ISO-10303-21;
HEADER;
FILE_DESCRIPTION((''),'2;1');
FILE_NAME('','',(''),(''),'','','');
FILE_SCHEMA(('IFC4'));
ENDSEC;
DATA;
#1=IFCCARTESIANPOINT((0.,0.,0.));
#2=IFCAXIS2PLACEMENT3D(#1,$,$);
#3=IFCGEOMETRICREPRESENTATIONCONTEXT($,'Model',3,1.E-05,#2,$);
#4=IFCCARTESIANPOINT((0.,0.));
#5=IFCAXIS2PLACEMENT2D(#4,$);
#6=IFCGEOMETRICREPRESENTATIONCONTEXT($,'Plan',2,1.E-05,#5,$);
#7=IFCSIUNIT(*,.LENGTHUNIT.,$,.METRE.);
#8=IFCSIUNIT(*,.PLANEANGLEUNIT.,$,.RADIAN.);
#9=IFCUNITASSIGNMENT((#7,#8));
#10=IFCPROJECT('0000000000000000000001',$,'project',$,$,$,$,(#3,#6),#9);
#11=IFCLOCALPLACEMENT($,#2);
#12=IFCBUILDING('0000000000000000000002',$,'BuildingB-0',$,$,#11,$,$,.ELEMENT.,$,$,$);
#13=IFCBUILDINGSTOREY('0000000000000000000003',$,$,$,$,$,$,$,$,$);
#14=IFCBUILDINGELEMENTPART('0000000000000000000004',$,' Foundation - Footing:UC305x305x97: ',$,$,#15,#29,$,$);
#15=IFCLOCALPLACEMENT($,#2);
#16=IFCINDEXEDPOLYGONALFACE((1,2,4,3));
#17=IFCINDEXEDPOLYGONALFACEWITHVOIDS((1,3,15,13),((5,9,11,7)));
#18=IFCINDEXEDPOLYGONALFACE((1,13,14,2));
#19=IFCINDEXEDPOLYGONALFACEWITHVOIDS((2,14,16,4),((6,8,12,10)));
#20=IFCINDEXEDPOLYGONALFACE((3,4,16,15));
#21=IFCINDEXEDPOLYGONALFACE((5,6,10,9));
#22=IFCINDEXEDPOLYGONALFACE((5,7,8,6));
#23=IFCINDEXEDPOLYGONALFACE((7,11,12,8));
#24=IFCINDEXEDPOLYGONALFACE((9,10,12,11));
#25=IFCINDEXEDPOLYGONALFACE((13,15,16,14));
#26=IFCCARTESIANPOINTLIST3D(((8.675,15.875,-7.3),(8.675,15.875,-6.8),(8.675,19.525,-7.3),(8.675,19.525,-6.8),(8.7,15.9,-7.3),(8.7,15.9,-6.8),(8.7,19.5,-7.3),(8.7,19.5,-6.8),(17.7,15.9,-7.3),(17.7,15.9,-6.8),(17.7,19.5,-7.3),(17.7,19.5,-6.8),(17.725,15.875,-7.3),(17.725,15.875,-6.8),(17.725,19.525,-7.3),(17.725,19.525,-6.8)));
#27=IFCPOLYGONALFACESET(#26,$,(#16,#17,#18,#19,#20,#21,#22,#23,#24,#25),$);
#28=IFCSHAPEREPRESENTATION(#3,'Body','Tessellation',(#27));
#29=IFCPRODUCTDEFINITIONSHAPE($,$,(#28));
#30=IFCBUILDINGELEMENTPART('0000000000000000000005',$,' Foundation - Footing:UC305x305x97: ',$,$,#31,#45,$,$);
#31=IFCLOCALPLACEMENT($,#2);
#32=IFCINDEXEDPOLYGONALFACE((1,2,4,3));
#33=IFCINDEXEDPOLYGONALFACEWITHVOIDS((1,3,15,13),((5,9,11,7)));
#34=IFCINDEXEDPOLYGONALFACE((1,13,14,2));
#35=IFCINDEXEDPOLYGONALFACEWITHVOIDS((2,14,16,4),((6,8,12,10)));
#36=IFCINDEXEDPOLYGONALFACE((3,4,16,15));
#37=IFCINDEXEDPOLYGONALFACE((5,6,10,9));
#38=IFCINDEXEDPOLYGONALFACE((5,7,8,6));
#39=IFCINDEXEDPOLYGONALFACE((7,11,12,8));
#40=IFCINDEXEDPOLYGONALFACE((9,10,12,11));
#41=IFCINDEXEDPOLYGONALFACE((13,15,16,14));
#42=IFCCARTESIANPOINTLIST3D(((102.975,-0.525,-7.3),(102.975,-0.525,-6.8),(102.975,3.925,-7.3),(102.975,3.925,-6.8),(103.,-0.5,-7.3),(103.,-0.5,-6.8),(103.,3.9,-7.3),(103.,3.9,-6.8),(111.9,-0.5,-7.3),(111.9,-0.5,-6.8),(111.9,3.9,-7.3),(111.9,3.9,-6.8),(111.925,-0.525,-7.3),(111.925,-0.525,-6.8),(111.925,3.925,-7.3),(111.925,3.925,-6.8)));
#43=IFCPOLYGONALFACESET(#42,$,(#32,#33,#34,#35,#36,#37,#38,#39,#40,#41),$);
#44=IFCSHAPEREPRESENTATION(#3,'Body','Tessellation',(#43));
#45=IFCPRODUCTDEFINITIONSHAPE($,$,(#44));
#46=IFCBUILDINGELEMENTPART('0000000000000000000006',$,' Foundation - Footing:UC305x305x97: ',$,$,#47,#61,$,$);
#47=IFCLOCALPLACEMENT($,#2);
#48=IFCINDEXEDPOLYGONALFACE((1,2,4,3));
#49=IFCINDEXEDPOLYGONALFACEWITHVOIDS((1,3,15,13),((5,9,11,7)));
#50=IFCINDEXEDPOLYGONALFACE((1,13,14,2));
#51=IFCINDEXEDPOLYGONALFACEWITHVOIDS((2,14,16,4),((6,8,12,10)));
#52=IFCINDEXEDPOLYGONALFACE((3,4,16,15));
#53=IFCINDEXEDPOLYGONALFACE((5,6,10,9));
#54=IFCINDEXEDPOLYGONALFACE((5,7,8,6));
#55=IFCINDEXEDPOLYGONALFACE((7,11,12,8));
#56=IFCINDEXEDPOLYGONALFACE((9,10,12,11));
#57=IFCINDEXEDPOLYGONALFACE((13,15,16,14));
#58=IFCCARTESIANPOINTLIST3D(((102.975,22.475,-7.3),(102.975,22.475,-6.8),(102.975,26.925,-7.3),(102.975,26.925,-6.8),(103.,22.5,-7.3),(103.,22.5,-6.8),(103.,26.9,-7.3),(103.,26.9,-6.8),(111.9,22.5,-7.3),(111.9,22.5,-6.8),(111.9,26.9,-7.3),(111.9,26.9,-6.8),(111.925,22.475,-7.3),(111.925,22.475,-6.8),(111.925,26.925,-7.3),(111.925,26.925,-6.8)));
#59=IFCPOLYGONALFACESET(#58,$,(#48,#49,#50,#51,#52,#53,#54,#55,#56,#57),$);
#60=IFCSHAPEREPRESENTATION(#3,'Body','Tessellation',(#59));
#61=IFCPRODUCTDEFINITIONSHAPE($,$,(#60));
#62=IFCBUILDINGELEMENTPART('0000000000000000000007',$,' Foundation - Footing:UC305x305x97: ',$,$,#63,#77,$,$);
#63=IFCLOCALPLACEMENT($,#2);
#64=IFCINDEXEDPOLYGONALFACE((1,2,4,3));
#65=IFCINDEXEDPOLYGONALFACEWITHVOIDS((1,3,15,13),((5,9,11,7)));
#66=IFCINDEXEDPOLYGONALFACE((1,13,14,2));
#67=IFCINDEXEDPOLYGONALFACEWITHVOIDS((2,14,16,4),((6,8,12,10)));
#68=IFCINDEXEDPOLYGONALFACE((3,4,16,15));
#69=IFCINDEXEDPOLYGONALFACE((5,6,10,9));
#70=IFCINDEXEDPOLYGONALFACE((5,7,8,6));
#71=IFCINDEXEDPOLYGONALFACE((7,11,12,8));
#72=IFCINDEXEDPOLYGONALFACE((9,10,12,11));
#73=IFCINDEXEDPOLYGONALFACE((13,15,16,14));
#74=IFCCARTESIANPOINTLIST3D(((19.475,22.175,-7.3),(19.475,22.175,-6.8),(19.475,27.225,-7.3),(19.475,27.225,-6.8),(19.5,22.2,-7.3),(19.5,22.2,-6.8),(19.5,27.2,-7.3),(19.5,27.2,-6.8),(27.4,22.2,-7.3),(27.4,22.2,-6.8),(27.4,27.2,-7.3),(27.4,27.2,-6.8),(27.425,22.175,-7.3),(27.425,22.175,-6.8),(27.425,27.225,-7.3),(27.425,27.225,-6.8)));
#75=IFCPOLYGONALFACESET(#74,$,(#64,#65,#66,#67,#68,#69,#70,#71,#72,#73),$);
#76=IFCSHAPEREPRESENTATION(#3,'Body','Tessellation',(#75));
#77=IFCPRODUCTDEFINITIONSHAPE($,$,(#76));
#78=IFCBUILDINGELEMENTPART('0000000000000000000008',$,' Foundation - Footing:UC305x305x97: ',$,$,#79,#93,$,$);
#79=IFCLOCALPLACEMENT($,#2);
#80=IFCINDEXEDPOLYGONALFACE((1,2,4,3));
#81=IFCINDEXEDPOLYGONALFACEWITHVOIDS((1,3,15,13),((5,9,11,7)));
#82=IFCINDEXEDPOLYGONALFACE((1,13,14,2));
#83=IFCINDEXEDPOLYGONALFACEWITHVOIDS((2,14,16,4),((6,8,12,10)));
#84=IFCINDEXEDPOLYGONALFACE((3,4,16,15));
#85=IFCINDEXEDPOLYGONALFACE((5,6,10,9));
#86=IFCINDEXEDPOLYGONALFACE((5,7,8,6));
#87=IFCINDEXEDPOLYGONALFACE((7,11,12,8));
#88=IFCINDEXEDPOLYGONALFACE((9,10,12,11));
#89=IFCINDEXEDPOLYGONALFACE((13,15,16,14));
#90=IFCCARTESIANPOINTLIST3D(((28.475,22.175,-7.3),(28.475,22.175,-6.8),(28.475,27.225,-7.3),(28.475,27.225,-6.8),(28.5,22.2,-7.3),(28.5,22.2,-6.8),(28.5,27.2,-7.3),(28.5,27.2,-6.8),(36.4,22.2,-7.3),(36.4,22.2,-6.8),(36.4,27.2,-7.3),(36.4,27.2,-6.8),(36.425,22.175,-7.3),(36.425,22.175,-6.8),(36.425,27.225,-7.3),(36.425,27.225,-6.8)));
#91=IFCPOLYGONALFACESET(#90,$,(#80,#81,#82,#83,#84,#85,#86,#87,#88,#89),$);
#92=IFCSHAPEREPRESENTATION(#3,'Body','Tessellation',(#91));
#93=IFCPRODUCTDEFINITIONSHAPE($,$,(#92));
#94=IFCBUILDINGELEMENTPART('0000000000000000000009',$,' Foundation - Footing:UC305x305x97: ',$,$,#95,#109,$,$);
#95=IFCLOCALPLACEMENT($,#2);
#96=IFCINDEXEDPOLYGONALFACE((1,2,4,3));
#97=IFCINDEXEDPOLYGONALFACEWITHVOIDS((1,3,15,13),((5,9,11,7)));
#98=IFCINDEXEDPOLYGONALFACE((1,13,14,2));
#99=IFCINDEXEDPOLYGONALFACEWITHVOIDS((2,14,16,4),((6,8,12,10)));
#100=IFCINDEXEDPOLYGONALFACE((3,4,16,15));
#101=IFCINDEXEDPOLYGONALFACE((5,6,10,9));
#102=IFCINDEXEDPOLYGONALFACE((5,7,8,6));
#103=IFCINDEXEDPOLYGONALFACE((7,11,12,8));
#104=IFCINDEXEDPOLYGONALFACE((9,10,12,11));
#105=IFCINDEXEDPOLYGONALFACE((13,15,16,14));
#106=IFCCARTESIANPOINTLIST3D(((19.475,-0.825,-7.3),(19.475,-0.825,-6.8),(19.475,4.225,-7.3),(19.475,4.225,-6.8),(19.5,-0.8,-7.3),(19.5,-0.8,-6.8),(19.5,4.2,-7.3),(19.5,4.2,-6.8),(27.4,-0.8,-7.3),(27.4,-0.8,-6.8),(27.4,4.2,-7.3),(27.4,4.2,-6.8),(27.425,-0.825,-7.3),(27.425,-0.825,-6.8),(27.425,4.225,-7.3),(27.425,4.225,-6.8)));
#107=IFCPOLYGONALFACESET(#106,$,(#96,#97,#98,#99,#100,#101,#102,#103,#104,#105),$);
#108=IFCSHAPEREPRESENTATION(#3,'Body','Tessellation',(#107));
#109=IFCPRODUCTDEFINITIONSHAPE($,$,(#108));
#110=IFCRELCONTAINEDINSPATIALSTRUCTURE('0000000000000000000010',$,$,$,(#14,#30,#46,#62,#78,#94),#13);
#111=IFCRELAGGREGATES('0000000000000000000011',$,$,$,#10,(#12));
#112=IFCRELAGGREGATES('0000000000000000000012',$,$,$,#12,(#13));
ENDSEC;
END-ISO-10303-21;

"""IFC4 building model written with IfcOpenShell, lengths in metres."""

from ifc_helpers import new_model, si_unit, origin, origin_2d, place, context, project, spatial, polyline, outline, extrude, element, save


model = new_model("IFC4")

# Units and contexts
model_context = context("Model", 3, precision=1e-05, world=origin())
plan_context = context("Plan", 2, precision=1e-05, world=origin_2d())
ifc_project = project(units=[si_unit("LENGTHUNIT", "METRE"), si_unit("PLANEANGLEUNIT", "RADIAN")], contexts=[model_context, plan_context])

# Building, storey
building_placement = place(None, origin())
building = spatial("IfcBuilding", under=ifc_project, at=building_placement, Name="BuildingB-0", CompositionType="ELEMENT")
storey = spatial("IfcBuildingStorey", under=building)

# Building element parts, openings
building_element_part_1 = element("IfcBuildingElementPart", 1, inside=storey, Name=" Foundation - Footing:UC305x305x97: ", context=model_context, shape_type="SweptSolid", body=[
    extrude(outline(polyline([(17.725, 19.525, -7.3), (8.675, 19.525, -7.3), (8.675, 15.875, -7.3), (17.725, 15.875, -7.3), (17.725, 19.525, -7.3)])), None, (0.0, 0.0, 1.0), 0.5),
])
element("IfcOpeningElement", 2, inside=storey, cuts=building_element_part_1, context=model_context, shape_type="SweptSolid", body=[
    extrude(outline(polyline([(17.7, 19.5, -7.3), (8.7, 19.5, -7.3), (8.7, 15.9, -7.3), (17.7, 15.9, -7.3), (17.7, 19.5, -7.3)])), None, (0.0, 0.0, 1.0), 0.5),
])
building_element_part_2 = element("IfcBuildingElementPart", 3, inside=storey, Name=" Foundation - Footing:UC305x305x97: ", context=model_context, shape_type="SweptSolid", body=[
    extrude(outline(polyline([(111.925, 3.925, -7.3), (102.975, 3.925, -7.3), (102.975, -0.525, -7.3), (111.925, -0.525, -7.3), (111.925, 3.925, -7.3)])), None, (0.0, 0.0, 1.0), 0.5),
])
element("IfcOpeningElement", 4, inside=storey, cuts=building_element_part_2, context=model_context, shape_type="SweptSolid", body=[
    extrude(outline(polyline([(111.9, 3.9, -7.3), (103.0, 3.9, -7.3), (103.0, -0.5, -7.3), (111.9, -0.5, -7.3), (111.9, 3.9, -7.3)])), None, (0.0, 0.0, 1.0), 0.5),
])
building_element_part_3 = element("IfcBuildingElementPart", 5, inside=storey, Name=" Foundation - Footing:UC305x305x97: ", context=model_context, shape_type="SweptSolid", body=[
    extrude(outline(polyline([(111.925, 26.925, -7.3), (102.975, 26.925, -7.3), (102.975, 22.475, -7.3), (111.925, 22.475, -7.3), (111.925, 26.925, -7.3)])), None, (0.0, 0.0, 1.0), 0.5),
])
element("IfcOpeningElement", 6, inside=storey, cuts=building_element_part_3, context=model_context, shape_type="SweptSolid", body=[
    extrude(outline(polyline([(111.9, 26.9, -7.3), (103.0, 26.9, -7.3), (103.0, 22.5, -7.3), (111.9, 22.5, -7.3), (111.9, 26.9, -7.3)])), None, (0.0, 0.0, 1.0), 0.5),
])
building_element_part_4 = element("IfcBuildingElementPart", 7, inside=storey, Name=" Foundation - Footing:UC305x305x97: ", context=model_context, shape_type="SweptSolid", body=[
    extrude(outline(polyline([(27.425, 27.225, -7.3), (19.475, 27.225, -7.3), (19.475, 22.175, -7.3), (27.425, 22.175, -7.3), (27.425, 27.225, -7.3)])), None, (0.0, 0.0, 1.0), 0.5),
])
element("IfcOpeningElement", 8, inside=storey, cuts=building_element_part_4, context=model_context, shape_type="SweptSolid", body=[
    extrude(outline(polyline([(27.4, 27.2, -7.3), (19.5, 27.2, -7.3), (19.5, 22.2, -7.3), (27.4, 22.2, -7.3), (27.4, 27.2, -7.3)])), None, (0.0, 0.0, 1.0), 0.5),
])
building_element_part_5 = element("IfcBuildingElementPart", 9, inside=storey, Name=" Foundation - Footing:UC305x305x97: ", context=model_context, shape_type="SweptSolid", body=[
    extrude(outline(polyline([(36.425, 27.225, -7.3), (28.475, 27.225, -7.3), (28.475, 22.175, -7.3), (36.425, 22.175, -7.3), (36.425, 27.225, -7.3)])), None, (0.0, 0.0, 1.0), 0.5),
])
element("IfcOpeningElement", 10, inside=storey, cuts=building_element_part_5, context=model_context, shape_type="SweptSolid", body=[
    extrude(outline(polyline([(36.4, 27.2, -7.3), (28.5, 27.2, -7.3), (28.5, 22.2, -7.3), (36.4, 22.2, -7.3), (36.4, 27.2, -7.3)])), None, (0.0, 0.0, 1.0), 0.5),
])
building_element_part_6 = element("IfcBuildingElementPart", 11, inside=storey, Name=" Foundation - Footing:UC305x305x97: ", context=model_context, shape_type="SweptSolid", body=[
    extrude(outline(polyline([(27.425, 4.225, -7.3), (19.475, 4.225, -7.3), (19.475, -0.825, -7.3), (27.425, -0.825, -7.3), (27.425, 4.225, -7.3)])), None, (0.0, 0.0, 1.0), 0.5),
])
element("IfcOpeningElement", 12, inside=storey, cuts=building_element_part_6, context=model_context, shape_type="SweptSolid", body=[
    extrude(outline(polyline([(27.4, 4.2, -7.3), (19.5, 4.2, -7.3), (19.5, -0.8, -7.3), (27.4, -0.8, -7.3), (27.4, 4.2, -7.3)])), None, (0.0, 0.0, 1.0), 0.5),
])

save(model, "model.ifc")
